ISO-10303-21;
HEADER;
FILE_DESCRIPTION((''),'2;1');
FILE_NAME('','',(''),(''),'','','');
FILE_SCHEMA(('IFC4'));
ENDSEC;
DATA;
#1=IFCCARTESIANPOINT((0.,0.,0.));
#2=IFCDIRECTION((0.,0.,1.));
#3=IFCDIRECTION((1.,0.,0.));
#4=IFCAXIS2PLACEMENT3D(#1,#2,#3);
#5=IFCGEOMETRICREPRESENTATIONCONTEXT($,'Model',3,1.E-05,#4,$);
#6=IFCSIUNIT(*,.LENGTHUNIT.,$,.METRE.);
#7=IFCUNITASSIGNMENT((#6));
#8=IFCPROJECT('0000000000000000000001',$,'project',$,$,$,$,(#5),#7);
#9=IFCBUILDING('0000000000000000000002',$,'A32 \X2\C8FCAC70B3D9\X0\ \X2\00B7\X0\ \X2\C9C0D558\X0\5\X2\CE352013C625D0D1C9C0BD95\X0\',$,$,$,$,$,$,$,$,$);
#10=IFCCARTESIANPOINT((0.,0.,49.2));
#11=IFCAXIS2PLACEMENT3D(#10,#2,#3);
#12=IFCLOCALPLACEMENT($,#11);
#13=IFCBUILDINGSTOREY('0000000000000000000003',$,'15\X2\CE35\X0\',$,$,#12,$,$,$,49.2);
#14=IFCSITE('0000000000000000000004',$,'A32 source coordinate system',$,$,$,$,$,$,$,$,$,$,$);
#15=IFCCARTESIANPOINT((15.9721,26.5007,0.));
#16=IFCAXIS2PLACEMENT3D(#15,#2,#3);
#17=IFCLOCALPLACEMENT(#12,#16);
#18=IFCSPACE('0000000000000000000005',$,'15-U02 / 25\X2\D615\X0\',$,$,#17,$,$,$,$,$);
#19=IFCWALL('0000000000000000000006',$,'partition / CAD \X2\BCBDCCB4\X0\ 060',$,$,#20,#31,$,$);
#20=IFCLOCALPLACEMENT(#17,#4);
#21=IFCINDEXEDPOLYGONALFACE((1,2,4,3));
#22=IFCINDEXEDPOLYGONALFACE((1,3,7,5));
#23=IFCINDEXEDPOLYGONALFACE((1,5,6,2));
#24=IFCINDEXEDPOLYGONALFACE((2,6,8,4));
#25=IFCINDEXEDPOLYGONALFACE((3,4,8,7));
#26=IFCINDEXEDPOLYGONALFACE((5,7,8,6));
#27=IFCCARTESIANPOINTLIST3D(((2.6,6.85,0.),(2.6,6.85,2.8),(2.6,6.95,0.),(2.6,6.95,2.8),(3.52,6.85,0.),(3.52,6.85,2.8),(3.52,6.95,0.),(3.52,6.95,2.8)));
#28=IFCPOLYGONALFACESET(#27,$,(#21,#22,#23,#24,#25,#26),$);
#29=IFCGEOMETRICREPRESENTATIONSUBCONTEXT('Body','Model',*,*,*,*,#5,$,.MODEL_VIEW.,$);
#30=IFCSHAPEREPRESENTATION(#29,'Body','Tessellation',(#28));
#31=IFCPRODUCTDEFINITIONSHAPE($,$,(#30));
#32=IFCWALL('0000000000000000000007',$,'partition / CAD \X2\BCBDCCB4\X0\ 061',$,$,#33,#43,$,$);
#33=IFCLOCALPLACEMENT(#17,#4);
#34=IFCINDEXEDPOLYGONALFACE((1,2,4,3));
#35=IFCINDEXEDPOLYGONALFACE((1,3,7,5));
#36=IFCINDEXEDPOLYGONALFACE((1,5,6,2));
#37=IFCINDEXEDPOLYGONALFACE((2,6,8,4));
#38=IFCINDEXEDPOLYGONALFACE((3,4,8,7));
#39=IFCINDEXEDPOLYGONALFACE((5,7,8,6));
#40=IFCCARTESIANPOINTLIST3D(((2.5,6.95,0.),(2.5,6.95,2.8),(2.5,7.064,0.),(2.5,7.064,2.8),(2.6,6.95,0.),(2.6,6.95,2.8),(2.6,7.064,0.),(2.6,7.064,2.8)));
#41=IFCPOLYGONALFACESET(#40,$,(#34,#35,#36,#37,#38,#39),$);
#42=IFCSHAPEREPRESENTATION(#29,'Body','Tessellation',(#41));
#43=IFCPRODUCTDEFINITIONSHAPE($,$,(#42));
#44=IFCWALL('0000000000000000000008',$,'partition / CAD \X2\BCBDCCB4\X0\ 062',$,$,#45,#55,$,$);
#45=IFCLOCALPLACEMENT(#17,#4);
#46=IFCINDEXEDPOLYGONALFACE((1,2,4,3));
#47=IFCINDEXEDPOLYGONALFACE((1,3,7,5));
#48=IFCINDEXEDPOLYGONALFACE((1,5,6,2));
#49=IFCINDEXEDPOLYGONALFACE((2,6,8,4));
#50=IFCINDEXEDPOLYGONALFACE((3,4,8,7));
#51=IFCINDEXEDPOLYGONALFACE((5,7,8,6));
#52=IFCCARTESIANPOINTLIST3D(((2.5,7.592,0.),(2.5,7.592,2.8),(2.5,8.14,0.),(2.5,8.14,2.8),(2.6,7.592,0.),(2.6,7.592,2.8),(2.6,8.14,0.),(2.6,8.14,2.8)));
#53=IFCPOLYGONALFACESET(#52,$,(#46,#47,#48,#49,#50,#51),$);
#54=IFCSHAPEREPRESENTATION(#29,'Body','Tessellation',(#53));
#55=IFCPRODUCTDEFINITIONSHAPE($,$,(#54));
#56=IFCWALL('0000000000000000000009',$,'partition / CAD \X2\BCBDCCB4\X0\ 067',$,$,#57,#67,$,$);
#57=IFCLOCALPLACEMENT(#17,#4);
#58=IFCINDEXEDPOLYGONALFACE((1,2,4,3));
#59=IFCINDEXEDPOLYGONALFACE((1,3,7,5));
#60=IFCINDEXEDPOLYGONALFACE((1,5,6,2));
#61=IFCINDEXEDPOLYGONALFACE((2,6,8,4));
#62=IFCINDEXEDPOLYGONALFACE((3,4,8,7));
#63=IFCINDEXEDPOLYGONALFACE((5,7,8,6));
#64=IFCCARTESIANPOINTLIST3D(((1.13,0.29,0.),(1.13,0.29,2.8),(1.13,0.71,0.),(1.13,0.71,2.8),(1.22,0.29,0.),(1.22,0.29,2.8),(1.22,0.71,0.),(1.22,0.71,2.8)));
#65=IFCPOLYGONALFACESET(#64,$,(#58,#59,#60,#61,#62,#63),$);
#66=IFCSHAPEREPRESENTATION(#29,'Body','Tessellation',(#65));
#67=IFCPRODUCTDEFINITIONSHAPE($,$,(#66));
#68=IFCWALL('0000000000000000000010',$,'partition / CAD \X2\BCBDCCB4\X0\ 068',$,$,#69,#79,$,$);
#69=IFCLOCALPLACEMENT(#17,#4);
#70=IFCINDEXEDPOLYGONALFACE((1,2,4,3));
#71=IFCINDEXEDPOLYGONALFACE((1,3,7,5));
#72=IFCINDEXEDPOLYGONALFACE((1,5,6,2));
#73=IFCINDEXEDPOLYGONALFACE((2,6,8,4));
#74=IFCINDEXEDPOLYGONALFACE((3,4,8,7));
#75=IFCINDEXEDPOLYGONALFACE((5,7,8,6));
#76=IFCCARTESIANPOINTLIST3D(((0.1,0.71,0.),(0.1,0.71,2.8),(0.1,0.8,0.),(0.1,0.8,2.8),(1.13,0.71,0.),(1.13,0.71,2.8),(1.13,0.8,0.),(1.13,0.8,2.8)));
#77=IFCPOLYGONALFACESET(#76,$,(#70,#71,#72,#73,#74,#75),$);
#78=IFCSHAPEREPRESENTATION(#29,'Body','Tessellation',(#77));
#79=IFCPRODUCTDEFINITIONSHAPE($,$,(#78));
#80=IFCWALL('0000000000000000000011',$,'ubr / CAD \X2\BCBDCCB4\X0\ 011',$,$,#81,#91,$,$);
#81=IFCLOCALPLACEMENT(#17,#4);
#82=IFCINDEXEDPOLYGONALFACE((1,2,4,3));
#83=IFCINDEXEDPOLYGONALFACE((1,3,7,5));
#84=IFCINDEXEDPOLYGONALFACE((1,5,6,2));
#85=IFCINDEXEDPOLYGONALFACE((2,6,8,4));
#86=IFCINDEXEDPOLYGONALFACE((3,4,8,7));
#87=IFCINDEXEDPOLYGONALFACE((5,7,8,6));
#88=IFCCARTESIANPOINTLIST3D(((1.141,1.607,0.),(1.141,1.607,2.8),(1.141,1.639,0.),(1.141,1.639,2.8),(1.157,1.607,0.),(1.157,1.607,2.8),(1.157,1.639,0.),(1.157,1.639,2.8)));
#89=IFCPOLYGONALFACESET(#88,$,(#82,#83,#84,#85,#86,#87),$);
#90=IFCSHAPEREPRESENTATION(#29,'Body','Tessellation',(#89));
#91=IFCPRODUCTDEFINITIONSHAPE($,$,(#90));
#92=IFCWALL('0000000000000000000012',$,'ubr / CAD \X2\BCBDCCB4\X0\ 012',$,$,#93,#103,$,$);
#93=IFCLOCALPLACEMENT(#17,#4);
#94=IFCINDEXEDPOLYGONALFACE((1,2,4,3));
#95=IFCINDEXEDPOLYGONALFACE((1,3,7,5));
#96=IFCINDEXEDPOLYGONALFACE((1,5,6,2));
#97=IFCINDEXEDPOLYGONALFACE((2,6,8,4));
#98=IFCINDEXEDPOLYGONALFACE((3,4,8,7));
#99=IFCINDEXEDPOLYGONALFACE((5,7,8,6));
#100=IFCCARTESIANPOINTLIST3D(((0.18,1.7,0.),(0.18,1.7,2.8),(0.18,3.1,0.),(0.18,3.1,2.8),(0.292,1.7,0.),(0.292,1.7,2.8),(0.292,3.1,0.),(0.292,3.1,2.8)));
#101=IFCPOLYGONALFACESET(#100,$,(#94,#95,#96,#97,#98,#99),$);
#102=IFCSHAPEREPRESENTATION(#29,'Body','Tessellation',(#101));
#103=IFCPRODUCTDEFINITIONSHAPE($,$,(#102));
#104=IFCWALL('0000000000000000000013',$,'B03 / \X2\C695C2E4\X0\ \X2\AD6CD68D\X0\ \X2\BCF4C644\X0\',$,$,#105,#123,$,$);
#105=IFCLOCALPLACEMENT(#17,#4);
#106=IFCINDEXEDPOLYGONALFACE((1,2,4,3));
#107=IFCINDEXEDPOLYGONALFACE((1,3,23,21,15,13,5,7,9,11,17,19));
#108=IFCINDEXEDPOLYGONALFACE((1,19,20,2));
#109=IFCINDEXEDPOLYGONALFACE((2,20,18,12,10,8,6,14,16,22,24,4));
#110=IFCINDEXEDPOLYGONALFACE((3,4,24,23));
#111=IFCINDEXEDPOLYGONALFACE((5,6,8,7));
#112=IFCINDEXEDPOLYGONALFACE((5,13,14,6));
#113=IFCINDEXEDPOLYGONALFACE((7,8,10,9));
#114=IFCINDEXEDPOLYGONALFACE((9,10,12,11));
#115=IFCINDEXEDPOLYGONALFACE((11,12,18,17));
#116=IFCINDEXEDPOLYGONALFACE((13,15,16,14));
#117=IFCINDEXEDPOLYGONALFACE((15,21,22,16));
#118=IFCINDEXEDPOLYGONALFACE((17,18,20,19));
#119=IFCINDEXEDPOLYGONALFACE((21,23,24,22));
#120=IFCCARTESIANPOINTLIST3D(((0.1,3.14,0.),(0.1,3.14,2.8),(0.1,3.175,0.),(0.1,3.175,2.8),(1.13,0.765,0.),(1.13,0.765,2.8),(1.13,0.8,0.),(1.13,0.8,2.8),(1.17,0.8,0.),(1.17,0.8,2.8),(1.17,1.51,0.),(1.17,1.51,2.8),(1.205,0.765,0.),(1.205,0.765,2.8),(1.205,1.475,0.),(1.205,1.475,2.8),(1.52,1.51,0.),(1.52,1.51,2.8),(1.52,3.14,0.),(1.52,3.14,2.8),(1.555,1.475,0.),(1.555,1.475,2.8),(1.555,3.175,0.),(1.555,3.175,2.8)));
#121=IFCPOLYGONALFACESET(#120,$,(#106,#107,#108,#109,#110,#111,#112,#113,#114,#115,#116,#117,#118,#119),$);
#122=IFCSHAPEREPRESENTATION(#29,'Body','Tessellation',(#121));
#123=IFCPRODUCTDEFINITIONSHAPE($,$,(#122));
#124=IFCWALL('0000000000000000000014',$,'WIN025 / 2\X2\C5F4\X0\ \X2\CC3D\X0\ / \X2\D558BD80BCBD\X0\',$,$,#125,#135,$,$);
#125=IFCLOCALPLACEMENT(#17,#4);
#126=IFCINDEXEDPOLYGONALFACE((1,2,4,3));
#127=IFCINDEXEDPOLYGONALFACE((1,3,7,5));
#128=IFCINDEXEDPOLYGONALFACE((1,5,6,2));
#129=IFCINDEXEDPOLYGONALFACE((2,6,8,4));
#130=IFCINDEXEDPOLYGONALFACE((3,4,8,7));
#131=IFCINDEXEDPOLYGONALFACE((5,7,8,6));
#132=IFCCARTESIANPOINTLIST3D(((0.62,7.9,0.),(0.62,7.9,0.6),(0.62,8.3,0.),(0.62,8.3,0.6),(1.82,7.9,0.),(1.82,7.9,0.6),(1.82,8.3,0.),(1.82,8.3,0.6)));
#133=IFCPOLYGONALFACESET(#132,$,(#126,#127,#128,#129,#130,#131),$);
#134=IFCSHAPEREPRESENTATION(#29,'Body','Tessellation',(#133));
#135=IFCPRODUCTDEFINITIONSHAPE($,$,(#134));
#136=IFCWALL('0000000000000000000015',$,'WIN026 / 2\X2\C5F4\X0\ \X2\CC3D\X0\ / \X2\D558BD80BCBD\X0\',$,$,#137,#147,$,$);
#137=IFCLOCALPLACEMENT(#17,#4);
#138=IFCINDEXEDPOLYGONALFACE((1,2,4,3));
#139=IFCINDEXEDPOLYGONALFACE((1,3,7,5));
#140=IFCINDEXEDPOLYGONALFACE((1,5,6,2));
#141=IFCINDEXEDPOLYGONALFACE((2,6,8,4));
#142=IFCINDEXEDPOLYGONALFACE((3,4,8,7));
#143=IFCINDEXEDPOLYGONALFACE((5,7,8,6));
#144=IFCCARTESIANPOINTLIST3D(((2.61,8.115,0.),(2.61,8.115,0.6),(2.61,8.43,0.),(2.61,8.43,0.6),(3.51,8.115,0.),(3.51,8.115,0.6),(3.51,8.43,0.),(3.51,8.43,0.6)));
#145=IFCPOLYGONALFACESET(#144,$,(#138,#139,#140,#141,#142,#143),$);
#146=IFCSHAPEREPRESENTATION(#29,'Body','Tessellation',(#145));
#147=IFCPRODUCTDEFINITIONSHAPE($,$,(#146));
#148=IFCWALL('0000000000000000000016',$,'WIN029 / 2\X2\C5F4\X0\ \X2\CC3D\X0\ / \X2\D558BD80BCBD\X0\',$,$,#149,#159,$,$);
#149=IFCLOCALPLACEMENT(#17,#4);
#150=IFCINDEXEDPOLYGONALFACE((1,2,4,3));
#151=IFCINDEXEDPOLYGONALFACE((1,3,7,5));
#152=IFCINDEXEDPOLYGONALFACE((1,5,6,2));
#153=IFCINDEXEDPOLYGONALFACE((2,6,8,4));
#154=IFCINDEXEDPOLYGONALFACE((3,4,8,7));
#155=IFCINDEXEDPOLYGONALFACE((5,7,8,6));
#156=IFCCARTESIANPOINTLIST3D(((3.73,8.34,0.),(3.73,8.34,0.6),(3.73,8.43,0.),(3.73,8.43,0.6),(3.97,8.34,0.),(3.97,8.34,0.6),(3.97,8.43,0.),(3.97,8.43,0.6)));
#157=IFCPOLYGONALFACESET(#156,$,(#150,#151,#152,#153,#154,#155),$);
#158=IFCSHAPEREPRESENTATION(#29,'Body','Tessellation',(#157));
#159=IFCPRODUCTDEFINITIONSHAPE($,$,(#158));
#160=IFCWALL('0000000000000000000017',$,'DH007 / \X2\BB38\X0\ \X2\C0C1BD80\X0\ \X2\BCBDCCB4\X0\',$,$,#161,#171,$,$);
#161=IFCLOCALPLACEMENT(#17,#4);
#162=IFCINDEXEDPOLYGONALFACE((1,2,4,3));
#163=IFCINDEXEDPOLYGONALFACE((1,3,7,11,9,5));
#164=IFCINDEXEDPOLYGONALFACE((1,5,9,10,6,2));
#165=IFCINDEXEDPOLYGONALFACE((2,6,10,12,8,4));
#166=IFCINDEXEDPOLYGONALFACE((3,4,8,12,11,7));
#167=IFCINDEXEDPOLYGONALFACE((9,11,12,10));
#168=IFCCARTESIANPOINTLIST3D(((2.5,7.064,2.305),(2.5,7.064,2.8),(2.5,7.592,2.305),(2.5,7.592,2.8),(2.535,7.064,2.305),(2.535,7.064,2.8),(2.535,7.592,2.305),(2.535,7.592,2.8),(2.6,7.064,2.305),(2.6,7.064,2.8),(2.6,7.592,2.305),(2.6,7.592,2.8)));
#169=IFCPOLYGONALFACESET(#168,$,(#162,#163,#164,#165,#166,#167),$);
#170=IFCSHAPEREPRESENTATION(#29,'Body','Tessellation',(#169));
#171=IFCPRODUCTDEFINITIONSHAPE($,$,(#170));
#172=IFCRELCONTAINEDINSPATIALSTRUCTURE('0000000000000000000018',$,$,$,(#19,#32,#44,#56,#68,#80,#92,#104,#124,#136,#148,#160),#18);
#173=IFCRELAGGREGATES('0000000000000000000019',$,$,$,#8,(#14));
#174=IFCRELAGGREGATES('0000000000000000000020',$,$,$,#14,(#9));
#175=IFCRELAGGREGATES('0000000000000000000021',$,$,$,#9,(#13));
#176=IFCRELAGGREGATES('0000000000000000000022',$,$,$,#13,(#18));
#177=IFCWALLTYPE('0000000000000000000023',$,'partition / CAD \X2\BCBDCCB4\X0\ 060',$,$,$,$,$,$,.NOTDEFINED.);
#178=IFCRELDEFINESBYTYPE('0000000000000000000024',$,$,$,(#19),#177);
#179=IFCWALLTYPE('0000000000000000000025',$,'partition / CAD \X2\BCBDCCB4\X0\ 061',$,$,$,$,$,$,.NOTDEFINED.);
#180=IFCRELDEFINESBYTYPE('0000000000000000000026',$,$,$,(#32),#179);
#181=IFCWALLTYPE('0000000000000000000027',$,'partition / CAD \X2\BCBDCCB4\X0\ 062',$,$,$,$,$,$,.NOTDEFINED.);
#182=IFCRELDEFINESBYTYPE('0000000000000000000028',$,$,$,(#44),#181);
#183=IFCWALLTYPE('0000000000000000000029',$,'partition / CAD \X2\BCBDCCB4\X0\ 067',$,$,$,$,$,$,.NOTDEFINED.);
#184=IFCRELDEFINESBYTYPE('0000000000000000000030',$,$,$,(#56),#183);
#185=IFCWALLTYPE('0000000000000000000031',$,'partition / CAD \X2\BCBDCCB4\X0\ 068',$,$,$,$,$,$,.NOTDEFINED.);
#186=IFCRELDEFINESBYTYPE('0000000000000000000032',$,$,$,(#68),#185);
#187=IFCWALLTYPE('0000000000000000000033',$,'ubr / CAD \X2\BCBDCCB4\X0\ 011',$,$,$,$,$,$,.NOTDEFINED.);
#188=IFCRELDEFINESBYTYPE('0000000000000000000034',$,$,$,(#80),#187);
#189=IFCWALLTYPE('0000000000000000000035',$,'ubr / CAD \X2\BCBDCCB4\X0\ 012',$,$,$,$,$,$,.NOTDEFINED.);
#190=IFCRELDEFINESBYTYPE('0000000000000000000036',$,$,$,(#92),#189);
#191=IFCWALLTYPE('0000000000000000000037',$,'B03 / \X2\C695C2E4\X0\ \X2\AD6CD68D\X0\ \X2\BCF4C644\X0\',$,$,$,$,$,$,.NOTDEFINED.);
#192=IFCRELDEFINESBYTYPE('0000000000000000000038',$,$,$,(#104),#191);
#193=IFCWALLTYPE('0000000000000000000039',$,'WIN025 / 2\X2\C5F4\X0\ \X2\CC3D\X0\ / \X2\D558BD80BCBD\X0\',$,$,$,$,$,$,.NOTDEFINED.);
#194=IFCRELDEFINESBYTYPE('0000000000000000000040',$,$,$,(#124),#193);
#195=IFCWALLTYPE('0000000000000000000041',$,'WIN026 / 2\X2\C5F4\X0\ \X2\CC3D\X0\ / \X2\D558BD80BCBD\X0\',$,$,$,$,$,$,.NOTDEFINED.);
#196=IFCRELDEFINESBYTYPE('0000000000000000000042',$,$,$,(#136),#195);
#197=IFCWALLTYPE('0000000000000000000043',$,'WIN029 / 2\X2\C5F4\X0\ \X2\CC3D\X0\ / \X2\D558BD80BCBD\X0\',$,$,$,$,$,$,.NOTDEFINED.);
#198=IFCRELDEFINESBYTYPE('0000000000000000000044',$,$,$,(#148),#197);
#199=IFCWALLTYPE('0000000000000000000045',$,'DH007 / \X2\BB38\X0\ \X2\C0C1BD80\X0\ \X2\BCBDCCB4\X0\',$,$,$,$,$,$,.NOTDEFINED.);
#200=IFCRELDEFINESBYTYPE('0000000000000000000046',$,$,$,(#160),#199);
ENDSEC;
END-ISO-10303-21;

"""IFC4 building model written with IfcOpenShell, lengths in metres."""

from ifc_helpers import new_model, si_unit, frame, origin, origin_with_axes, place, context, subcontext, project, spatial, polyline, outline, extrude, source, transform, mapped, type_object, type_shapes, element, save


model = new_model("IFC4")

# Units and contexts
model_context = context("Model", 3, precision=1e-05, world=origin_with_axes())
body_context = subcontext(model_context, "Body", "Model", "MODEL_VIEW")
ifc_project = project(units=[si_unit("LENGTHUNIT", "METRE")], contexts=[model_context])

# Site, building, storey, space
site = spatial("IfcSite", under=ifc_project, Name="A32 source coordinate system")
building = spatial("IfcBuilding", under=site, Name="A32 주거동 · 지하5층–옥탑지붕")
storey_placement = place(None, frame((0.0, 0.0, 49.2), z_axis=(0.0, 0.0, 1.0), x_axis=(1.0, 0.0, 0.0)))
storey = spatial("IfcBuildingStorey", under=building, at=storey_placement, Name="15층", Elevation=49.2)
space_1_placement = place(storey_placement, frame((15.9721, 26.5007, 0.0), z_axis=(0.0, 0.0, 1.0), x_axis=(1.0, 0.0, 0.0)))
space_1 = spatial("IfcSpace", under=storey, at=space_1_placement, Name="15-U02 / 25형")

# Walls
wall_type_1 = type_object("IfcWallType", Name="partition / CAD 벽체 060", PredefinedType="NOTDEFINED")
shared_shape_1 = source(origin(), body_context, "Body", "SweptSolid", [
    extrude(outline(polyline([(3.52, 6.85), (2.6, 6.85), (2.6, 6.95), (3.52, 6.95), (3.52, 6.85)])), origin(), (0.0, 0.0, 1.0), 2.8),
])
type_shapes(wall_type_1, [shared_shape_1])
wall_1_placement = place(space_1_placement, origin_with_axes())
element("IfcWall", 1, at=wall_1_placement, inside=space_1, type_object=wall_type_1, Name="partition / CAD 벽체 060", context=body_context, shape_type="MappedRepresentation", body=[
    mapped(shared_shape_1, transform((0.0, 0.0, 0.0), scale=1.0)),
])
wall_type_2 = type_object("IfcWallType", Name="partition / CAD 벽체 061", PredefinedType="NOTDEFINED")
shared_shape_2 = source(origin(), body_context, "Body", "SweptSolid", [
    extrude(outline(polyline([(2.6, 7.064), (2.6, 6.95), (2.5, 6.95), (2.5, 7.064), (2.6, 7.064)])), origin(), (0.0, 0.0, 1.0), 2.8),
])
type_shapes(wall_type_2, [shared_shape_2])
wall_2_placement = place(space_1_placement, origin_with_axes())
element("IfcWall", 2, at=wall_2_placement, inside=space_1, type_object=wall_type_2, Name="partition / CAD 벽체 061", context=body_context, shape_type="MappedRepresentation", body=[
    mapped(shared_shape_2, transform((0.0, 0.0, 0.0), scale=1.0)),
])
wall_type_3 = type_object("IfcWallType", Name="partition / CAD 벽체 062", PredefinedType="NOTDEFINED")
shared_shape_3 = source(origin(), body_context, "Body", "SweptSolid", [
    extrude(outline(polyline([(2.5, 7.592), (2.5, 8.14), (2.6, 8.14), (2.6, 7.592), (2.5, 7.592)])), origin(), (0.0, 0.0, 1.0), 2.8),
])
type_shapes(wall_type_3, [shared_shape_3])
wall_3_placement = place(space_1_placement, origin_with_axes())
element("IfcWall", 3, at=wall_3_placement, inside=space_1, type_object=wall_type_3, Name="partition / CAD 벽체 062", context=body_context, shape_type="MappedRepresentation", body=[
    mapped(shared_shape_3, transform((0.0, 0.0, 0.0), scale=1.0)),
])
wall_type_4 = type_object("IfcWallType", Name="partition / CAD 벽체 067", PredefinedType="NOTDEFINED")
shared_shape_4 = source(origin(), body_context, "Body", "SweptSolid", [
    extrude(outline(polyline([(1.22, 0.71), (1.22, 0.29), (1.13, 0.29), (1.13, 0.71), (1.22, 0.71)])), origin(), (0.0, 0.0, 1.0), 2.8),
])
type_shapes(wall_type_4, [shared_shape_4])
wall_4_placement = place(space_1_placement, origin_with_axes())
element("IfcWall", 4, at=wall_4_placement, inside=space_1, type_object=wall_type_4, Name="partition / CAD 벽체 067", context=body_context, shape_type="MappedRepresentation", body=[
    mapped(shared_shape_4, transform((0.0, 0.0, 0.0), scale=1.0)),
])
wall_type_5 = type_object("IfcWallType", Name="partition / CAD 벽체 068", PredefinedType="NOTDEFINED")
shared_shape_5 = source(origin(), body_context, "Body", "SweptSolid", [
    extrude(outline(polyline([(1.13, 0.8), (1.13, 0.71), (0.1, 0.71), (0.1, 0.8), (1.13, 0.8)])), origin(), (0.0, 0.0, 1.0), 2.8),
])
type_shapes(wall_type_5, [shared_shape_5])
wall_5_placement = place(space_1_placement, origin_with_axes())
element("IfcWall", 5, at=wall_5_placement, inside=space_1, type_object=wall_type_5, Name="partition / CAD 벽체 068", context=body_context, shape_type="MappedRepresentation", body=[
    mapped(shared_shape_5, transform((0.0, 0.0, 0.0), scale=1.0)),
])
wall_type_6 = type_object("IfcWallType", Name="ubr / CAD 벽체 011", PredefinedType="NOTDEFINED")
shared_shape_6 = source(origin(), body_context, "Body", "SweptSolid", [
    extrude(outline(polyline([(1.141, 1.607), (1.141, 1.639), (1.157, 1.639), (1.157, 1.607), (1.141, 1.607)])), origin(), (0.0, 0.0, 1.0), 2.8),
])
type_shapes(wall_type_6, [shared_shape_6])
wall_6_placement = place(space_1_placement, origin_with_axes())
element("IfcWall", 6, at=wall_6_placement, inside=space_1, type_object=wall_type_6, Name="ubr / CAD 벽체 011", context=body_context, shape_type="MappedRepresentation", body=[
    mapped(shared_shape_6, transform((0.0, 0.0, 0.0), scale=1.0)),
])
wall_type_7 = type_object("IfcWallType", Name="ubr / CAD 벽체 012", PredefinedType="NOTDEFINED")
shared_shape_7 = source(origin(), body_context, "Body", "SweptSolid", [
    extrude(outline(polyline([(0.18, 1.7), (0.18, 3.1), (0.292, 3.1), (0.292, 1.7), (0.18, 1.7)])), origin(), (0.0, 0.0, 1.0), 2.8),
])
type_shapes(wall_type_7, [shared_shape_7])
wall_7_placement = place(space_1_placement, origin_with_axes())
element("IfcWall", 7, at=wall_7_placement, inside=space_1, type_object=wall_type_7, Name="ubr / CAD 벽체 012", context=body_context, shape_type="MappedRepresentation", body=[
    mapped(shared_shape_7, transform((0.0, 0.0, 0.0), scale=1.0)),
])
wall_type_8 = type_object("IfcWallType", Name="B03 / 욕실 구획 보완", PredefinedType="NOTDEFINED")
shared_shape_8 = source(origin(), body_context, "Body", "SweptSolid", [
    extrude(outline(polyline([(1.13, 0.765), (1.13, 0.8), (1.17, 0.8), (1.17, 1.51), (1.52, 1.51), (1.52, 3.14), (0.1, 3.14), (0.1, 3.175), (1.555, 3.175), (1.555, 1.475), (1.205, 1.475), (1.205, 0.765), (1.13, 0.765)])), origin(), (0.0, 0.0, 1.0), 2.8),
])
type_shapes(wall_type_8, [shared_shape_8])
wall_8_placement = place(space_1_placement, origin_with_axes())
element("IfcWall", 8, at=wall_8_placement, inside=space_1, type_object=wall_type_8, Name="B03 / 욕실 구획 보완", context=body_context, shape_type="MappedRepresentation", body=[
    mapped(shared_shape_8, transform((0.0, 0.0, 0.0), scale=1.0)),
])
wall_type_9 = type_object("IfcWallType", Name="WIN025 / 2열 창 / 하부벽", PredefinedType="NOTDEFINED")
shared_shape_9 = source(origin(), body_context, "Body", "SweptSolid", [
    extrude(outline(polyline([(1.82, 8.3), (1.82, 7.9), (0.62, 7.9), (0.62, 8.3), (1.82, 8.3)])), origin(), (0.0, 0.0, 1.0), 0.6),
])
type_shapes(wall_type_9, [shared_shape_9])
wall_9_placement = place(space_1_placement, origin_with_axes())
element("IfcWall", 9, at=wall_9_placement, inside=space_1, type_object=wall_type_9, Name="WIN025 / 2열 창 / 하부벽", context=body_context, shape_type="MappedRepresentation", body=[
    mapped(shared_shape_9, transform((0.0, 0.0, 0.0), scale=1.0)),
])
wall_type_10 = type_object("IfcWallType", Name="WIN026 / 2열 창 / 하부벽", PredefinedType="NOTDEFINED")
shared_shape_10 = source(origin(), body_context, "Body", "SweptSolid", [
    extrude(outline(polyline([(3.51, 8.43), (3.51, 8.115), (2.61, 8.115), (2.61, 8.43), (3.51, 8.43)])), origin(), (0.0, 0.0, 1.0), 0.6),
])
type_shapes(wall_type_10, [shared_shape_10])
wall_10_placement = place(space_1_placement, origin_with_axes())
element("IfcWall", 10, at=wall_10_placement, inside=space_1, type_object=wall_type_10, Name="WIN026 / 2열 창 / 하부벽", context=body_context, shape_type="MappedRepresentation", body=[
    mapped(shared_shape_10, transform((0.0, 0.0, 0.0), scale=1.0)),
])
wall_type_11 = type_object("IfcWallType", Name="WIN029 / 2열 창 / 하부벽", PredefinedType="NOTDEFINED")
shared_shape_11 = source(origin(), body_context, "Body", "SweptSolid", [
    extrude(outline(polyline([(3.97, 8.43), (3.97, 8.34), (3.73, 8.34), (3.73, 8.43), (3.97, 8.43)])), origin(), (0.0, 0.0, 1.0), 0.6),
])
type_shapes(wall_type_11, [shared_shape_11])
wall_11_placement = place(space_1_placement, origin_with_axes())
element("IfcWall", 11, at=wall_11_placement, inside=space_1, type_object=wall_type_11, Name="WIN029 / 2열 창 / 하부벽", context=body_context, shape_type="MappedRepresentation", body=[
    mapped(shared_shape_11, transform((0.0, 0.0, 0.0), scale=1.0)),
])
wall_type_12 = type_object("IfcWallType", Name="DH007 / 문 상부 벽체", PredefinedType="NOTDEFINED")
shared_shape_12 = source(origin(), body_context, "Body", "SweptSolid", [
    extrude(outline(polyline([(2.5, 7.592), (2.535, 7.592), (2.6, 7.592), (2.6, 7.064), (2.535, 7.064), (2.5, 7.064), (2.5, 7.592)])), frame((0.0, 0.0, 2.305)), (0.0, 0.0, 1.0), 0.495),
])
type_shapes(wall_type_12, [shared_shape_12])
wall_12_placement = place(space_1_placement, origin_with_axes())
element("IfcWall", 12, at=wall_12_placement, inside=space_1, type_object=wall_type_12, Name="DH007 / 문 상부 벽체", context=body_context, shape_type="MappedRepresentation", body=[
    mapped(shared_shape_12, transform((0.0, 0.0, 0.0), scale=1.0)),
])

save(model, "model.ifc")
